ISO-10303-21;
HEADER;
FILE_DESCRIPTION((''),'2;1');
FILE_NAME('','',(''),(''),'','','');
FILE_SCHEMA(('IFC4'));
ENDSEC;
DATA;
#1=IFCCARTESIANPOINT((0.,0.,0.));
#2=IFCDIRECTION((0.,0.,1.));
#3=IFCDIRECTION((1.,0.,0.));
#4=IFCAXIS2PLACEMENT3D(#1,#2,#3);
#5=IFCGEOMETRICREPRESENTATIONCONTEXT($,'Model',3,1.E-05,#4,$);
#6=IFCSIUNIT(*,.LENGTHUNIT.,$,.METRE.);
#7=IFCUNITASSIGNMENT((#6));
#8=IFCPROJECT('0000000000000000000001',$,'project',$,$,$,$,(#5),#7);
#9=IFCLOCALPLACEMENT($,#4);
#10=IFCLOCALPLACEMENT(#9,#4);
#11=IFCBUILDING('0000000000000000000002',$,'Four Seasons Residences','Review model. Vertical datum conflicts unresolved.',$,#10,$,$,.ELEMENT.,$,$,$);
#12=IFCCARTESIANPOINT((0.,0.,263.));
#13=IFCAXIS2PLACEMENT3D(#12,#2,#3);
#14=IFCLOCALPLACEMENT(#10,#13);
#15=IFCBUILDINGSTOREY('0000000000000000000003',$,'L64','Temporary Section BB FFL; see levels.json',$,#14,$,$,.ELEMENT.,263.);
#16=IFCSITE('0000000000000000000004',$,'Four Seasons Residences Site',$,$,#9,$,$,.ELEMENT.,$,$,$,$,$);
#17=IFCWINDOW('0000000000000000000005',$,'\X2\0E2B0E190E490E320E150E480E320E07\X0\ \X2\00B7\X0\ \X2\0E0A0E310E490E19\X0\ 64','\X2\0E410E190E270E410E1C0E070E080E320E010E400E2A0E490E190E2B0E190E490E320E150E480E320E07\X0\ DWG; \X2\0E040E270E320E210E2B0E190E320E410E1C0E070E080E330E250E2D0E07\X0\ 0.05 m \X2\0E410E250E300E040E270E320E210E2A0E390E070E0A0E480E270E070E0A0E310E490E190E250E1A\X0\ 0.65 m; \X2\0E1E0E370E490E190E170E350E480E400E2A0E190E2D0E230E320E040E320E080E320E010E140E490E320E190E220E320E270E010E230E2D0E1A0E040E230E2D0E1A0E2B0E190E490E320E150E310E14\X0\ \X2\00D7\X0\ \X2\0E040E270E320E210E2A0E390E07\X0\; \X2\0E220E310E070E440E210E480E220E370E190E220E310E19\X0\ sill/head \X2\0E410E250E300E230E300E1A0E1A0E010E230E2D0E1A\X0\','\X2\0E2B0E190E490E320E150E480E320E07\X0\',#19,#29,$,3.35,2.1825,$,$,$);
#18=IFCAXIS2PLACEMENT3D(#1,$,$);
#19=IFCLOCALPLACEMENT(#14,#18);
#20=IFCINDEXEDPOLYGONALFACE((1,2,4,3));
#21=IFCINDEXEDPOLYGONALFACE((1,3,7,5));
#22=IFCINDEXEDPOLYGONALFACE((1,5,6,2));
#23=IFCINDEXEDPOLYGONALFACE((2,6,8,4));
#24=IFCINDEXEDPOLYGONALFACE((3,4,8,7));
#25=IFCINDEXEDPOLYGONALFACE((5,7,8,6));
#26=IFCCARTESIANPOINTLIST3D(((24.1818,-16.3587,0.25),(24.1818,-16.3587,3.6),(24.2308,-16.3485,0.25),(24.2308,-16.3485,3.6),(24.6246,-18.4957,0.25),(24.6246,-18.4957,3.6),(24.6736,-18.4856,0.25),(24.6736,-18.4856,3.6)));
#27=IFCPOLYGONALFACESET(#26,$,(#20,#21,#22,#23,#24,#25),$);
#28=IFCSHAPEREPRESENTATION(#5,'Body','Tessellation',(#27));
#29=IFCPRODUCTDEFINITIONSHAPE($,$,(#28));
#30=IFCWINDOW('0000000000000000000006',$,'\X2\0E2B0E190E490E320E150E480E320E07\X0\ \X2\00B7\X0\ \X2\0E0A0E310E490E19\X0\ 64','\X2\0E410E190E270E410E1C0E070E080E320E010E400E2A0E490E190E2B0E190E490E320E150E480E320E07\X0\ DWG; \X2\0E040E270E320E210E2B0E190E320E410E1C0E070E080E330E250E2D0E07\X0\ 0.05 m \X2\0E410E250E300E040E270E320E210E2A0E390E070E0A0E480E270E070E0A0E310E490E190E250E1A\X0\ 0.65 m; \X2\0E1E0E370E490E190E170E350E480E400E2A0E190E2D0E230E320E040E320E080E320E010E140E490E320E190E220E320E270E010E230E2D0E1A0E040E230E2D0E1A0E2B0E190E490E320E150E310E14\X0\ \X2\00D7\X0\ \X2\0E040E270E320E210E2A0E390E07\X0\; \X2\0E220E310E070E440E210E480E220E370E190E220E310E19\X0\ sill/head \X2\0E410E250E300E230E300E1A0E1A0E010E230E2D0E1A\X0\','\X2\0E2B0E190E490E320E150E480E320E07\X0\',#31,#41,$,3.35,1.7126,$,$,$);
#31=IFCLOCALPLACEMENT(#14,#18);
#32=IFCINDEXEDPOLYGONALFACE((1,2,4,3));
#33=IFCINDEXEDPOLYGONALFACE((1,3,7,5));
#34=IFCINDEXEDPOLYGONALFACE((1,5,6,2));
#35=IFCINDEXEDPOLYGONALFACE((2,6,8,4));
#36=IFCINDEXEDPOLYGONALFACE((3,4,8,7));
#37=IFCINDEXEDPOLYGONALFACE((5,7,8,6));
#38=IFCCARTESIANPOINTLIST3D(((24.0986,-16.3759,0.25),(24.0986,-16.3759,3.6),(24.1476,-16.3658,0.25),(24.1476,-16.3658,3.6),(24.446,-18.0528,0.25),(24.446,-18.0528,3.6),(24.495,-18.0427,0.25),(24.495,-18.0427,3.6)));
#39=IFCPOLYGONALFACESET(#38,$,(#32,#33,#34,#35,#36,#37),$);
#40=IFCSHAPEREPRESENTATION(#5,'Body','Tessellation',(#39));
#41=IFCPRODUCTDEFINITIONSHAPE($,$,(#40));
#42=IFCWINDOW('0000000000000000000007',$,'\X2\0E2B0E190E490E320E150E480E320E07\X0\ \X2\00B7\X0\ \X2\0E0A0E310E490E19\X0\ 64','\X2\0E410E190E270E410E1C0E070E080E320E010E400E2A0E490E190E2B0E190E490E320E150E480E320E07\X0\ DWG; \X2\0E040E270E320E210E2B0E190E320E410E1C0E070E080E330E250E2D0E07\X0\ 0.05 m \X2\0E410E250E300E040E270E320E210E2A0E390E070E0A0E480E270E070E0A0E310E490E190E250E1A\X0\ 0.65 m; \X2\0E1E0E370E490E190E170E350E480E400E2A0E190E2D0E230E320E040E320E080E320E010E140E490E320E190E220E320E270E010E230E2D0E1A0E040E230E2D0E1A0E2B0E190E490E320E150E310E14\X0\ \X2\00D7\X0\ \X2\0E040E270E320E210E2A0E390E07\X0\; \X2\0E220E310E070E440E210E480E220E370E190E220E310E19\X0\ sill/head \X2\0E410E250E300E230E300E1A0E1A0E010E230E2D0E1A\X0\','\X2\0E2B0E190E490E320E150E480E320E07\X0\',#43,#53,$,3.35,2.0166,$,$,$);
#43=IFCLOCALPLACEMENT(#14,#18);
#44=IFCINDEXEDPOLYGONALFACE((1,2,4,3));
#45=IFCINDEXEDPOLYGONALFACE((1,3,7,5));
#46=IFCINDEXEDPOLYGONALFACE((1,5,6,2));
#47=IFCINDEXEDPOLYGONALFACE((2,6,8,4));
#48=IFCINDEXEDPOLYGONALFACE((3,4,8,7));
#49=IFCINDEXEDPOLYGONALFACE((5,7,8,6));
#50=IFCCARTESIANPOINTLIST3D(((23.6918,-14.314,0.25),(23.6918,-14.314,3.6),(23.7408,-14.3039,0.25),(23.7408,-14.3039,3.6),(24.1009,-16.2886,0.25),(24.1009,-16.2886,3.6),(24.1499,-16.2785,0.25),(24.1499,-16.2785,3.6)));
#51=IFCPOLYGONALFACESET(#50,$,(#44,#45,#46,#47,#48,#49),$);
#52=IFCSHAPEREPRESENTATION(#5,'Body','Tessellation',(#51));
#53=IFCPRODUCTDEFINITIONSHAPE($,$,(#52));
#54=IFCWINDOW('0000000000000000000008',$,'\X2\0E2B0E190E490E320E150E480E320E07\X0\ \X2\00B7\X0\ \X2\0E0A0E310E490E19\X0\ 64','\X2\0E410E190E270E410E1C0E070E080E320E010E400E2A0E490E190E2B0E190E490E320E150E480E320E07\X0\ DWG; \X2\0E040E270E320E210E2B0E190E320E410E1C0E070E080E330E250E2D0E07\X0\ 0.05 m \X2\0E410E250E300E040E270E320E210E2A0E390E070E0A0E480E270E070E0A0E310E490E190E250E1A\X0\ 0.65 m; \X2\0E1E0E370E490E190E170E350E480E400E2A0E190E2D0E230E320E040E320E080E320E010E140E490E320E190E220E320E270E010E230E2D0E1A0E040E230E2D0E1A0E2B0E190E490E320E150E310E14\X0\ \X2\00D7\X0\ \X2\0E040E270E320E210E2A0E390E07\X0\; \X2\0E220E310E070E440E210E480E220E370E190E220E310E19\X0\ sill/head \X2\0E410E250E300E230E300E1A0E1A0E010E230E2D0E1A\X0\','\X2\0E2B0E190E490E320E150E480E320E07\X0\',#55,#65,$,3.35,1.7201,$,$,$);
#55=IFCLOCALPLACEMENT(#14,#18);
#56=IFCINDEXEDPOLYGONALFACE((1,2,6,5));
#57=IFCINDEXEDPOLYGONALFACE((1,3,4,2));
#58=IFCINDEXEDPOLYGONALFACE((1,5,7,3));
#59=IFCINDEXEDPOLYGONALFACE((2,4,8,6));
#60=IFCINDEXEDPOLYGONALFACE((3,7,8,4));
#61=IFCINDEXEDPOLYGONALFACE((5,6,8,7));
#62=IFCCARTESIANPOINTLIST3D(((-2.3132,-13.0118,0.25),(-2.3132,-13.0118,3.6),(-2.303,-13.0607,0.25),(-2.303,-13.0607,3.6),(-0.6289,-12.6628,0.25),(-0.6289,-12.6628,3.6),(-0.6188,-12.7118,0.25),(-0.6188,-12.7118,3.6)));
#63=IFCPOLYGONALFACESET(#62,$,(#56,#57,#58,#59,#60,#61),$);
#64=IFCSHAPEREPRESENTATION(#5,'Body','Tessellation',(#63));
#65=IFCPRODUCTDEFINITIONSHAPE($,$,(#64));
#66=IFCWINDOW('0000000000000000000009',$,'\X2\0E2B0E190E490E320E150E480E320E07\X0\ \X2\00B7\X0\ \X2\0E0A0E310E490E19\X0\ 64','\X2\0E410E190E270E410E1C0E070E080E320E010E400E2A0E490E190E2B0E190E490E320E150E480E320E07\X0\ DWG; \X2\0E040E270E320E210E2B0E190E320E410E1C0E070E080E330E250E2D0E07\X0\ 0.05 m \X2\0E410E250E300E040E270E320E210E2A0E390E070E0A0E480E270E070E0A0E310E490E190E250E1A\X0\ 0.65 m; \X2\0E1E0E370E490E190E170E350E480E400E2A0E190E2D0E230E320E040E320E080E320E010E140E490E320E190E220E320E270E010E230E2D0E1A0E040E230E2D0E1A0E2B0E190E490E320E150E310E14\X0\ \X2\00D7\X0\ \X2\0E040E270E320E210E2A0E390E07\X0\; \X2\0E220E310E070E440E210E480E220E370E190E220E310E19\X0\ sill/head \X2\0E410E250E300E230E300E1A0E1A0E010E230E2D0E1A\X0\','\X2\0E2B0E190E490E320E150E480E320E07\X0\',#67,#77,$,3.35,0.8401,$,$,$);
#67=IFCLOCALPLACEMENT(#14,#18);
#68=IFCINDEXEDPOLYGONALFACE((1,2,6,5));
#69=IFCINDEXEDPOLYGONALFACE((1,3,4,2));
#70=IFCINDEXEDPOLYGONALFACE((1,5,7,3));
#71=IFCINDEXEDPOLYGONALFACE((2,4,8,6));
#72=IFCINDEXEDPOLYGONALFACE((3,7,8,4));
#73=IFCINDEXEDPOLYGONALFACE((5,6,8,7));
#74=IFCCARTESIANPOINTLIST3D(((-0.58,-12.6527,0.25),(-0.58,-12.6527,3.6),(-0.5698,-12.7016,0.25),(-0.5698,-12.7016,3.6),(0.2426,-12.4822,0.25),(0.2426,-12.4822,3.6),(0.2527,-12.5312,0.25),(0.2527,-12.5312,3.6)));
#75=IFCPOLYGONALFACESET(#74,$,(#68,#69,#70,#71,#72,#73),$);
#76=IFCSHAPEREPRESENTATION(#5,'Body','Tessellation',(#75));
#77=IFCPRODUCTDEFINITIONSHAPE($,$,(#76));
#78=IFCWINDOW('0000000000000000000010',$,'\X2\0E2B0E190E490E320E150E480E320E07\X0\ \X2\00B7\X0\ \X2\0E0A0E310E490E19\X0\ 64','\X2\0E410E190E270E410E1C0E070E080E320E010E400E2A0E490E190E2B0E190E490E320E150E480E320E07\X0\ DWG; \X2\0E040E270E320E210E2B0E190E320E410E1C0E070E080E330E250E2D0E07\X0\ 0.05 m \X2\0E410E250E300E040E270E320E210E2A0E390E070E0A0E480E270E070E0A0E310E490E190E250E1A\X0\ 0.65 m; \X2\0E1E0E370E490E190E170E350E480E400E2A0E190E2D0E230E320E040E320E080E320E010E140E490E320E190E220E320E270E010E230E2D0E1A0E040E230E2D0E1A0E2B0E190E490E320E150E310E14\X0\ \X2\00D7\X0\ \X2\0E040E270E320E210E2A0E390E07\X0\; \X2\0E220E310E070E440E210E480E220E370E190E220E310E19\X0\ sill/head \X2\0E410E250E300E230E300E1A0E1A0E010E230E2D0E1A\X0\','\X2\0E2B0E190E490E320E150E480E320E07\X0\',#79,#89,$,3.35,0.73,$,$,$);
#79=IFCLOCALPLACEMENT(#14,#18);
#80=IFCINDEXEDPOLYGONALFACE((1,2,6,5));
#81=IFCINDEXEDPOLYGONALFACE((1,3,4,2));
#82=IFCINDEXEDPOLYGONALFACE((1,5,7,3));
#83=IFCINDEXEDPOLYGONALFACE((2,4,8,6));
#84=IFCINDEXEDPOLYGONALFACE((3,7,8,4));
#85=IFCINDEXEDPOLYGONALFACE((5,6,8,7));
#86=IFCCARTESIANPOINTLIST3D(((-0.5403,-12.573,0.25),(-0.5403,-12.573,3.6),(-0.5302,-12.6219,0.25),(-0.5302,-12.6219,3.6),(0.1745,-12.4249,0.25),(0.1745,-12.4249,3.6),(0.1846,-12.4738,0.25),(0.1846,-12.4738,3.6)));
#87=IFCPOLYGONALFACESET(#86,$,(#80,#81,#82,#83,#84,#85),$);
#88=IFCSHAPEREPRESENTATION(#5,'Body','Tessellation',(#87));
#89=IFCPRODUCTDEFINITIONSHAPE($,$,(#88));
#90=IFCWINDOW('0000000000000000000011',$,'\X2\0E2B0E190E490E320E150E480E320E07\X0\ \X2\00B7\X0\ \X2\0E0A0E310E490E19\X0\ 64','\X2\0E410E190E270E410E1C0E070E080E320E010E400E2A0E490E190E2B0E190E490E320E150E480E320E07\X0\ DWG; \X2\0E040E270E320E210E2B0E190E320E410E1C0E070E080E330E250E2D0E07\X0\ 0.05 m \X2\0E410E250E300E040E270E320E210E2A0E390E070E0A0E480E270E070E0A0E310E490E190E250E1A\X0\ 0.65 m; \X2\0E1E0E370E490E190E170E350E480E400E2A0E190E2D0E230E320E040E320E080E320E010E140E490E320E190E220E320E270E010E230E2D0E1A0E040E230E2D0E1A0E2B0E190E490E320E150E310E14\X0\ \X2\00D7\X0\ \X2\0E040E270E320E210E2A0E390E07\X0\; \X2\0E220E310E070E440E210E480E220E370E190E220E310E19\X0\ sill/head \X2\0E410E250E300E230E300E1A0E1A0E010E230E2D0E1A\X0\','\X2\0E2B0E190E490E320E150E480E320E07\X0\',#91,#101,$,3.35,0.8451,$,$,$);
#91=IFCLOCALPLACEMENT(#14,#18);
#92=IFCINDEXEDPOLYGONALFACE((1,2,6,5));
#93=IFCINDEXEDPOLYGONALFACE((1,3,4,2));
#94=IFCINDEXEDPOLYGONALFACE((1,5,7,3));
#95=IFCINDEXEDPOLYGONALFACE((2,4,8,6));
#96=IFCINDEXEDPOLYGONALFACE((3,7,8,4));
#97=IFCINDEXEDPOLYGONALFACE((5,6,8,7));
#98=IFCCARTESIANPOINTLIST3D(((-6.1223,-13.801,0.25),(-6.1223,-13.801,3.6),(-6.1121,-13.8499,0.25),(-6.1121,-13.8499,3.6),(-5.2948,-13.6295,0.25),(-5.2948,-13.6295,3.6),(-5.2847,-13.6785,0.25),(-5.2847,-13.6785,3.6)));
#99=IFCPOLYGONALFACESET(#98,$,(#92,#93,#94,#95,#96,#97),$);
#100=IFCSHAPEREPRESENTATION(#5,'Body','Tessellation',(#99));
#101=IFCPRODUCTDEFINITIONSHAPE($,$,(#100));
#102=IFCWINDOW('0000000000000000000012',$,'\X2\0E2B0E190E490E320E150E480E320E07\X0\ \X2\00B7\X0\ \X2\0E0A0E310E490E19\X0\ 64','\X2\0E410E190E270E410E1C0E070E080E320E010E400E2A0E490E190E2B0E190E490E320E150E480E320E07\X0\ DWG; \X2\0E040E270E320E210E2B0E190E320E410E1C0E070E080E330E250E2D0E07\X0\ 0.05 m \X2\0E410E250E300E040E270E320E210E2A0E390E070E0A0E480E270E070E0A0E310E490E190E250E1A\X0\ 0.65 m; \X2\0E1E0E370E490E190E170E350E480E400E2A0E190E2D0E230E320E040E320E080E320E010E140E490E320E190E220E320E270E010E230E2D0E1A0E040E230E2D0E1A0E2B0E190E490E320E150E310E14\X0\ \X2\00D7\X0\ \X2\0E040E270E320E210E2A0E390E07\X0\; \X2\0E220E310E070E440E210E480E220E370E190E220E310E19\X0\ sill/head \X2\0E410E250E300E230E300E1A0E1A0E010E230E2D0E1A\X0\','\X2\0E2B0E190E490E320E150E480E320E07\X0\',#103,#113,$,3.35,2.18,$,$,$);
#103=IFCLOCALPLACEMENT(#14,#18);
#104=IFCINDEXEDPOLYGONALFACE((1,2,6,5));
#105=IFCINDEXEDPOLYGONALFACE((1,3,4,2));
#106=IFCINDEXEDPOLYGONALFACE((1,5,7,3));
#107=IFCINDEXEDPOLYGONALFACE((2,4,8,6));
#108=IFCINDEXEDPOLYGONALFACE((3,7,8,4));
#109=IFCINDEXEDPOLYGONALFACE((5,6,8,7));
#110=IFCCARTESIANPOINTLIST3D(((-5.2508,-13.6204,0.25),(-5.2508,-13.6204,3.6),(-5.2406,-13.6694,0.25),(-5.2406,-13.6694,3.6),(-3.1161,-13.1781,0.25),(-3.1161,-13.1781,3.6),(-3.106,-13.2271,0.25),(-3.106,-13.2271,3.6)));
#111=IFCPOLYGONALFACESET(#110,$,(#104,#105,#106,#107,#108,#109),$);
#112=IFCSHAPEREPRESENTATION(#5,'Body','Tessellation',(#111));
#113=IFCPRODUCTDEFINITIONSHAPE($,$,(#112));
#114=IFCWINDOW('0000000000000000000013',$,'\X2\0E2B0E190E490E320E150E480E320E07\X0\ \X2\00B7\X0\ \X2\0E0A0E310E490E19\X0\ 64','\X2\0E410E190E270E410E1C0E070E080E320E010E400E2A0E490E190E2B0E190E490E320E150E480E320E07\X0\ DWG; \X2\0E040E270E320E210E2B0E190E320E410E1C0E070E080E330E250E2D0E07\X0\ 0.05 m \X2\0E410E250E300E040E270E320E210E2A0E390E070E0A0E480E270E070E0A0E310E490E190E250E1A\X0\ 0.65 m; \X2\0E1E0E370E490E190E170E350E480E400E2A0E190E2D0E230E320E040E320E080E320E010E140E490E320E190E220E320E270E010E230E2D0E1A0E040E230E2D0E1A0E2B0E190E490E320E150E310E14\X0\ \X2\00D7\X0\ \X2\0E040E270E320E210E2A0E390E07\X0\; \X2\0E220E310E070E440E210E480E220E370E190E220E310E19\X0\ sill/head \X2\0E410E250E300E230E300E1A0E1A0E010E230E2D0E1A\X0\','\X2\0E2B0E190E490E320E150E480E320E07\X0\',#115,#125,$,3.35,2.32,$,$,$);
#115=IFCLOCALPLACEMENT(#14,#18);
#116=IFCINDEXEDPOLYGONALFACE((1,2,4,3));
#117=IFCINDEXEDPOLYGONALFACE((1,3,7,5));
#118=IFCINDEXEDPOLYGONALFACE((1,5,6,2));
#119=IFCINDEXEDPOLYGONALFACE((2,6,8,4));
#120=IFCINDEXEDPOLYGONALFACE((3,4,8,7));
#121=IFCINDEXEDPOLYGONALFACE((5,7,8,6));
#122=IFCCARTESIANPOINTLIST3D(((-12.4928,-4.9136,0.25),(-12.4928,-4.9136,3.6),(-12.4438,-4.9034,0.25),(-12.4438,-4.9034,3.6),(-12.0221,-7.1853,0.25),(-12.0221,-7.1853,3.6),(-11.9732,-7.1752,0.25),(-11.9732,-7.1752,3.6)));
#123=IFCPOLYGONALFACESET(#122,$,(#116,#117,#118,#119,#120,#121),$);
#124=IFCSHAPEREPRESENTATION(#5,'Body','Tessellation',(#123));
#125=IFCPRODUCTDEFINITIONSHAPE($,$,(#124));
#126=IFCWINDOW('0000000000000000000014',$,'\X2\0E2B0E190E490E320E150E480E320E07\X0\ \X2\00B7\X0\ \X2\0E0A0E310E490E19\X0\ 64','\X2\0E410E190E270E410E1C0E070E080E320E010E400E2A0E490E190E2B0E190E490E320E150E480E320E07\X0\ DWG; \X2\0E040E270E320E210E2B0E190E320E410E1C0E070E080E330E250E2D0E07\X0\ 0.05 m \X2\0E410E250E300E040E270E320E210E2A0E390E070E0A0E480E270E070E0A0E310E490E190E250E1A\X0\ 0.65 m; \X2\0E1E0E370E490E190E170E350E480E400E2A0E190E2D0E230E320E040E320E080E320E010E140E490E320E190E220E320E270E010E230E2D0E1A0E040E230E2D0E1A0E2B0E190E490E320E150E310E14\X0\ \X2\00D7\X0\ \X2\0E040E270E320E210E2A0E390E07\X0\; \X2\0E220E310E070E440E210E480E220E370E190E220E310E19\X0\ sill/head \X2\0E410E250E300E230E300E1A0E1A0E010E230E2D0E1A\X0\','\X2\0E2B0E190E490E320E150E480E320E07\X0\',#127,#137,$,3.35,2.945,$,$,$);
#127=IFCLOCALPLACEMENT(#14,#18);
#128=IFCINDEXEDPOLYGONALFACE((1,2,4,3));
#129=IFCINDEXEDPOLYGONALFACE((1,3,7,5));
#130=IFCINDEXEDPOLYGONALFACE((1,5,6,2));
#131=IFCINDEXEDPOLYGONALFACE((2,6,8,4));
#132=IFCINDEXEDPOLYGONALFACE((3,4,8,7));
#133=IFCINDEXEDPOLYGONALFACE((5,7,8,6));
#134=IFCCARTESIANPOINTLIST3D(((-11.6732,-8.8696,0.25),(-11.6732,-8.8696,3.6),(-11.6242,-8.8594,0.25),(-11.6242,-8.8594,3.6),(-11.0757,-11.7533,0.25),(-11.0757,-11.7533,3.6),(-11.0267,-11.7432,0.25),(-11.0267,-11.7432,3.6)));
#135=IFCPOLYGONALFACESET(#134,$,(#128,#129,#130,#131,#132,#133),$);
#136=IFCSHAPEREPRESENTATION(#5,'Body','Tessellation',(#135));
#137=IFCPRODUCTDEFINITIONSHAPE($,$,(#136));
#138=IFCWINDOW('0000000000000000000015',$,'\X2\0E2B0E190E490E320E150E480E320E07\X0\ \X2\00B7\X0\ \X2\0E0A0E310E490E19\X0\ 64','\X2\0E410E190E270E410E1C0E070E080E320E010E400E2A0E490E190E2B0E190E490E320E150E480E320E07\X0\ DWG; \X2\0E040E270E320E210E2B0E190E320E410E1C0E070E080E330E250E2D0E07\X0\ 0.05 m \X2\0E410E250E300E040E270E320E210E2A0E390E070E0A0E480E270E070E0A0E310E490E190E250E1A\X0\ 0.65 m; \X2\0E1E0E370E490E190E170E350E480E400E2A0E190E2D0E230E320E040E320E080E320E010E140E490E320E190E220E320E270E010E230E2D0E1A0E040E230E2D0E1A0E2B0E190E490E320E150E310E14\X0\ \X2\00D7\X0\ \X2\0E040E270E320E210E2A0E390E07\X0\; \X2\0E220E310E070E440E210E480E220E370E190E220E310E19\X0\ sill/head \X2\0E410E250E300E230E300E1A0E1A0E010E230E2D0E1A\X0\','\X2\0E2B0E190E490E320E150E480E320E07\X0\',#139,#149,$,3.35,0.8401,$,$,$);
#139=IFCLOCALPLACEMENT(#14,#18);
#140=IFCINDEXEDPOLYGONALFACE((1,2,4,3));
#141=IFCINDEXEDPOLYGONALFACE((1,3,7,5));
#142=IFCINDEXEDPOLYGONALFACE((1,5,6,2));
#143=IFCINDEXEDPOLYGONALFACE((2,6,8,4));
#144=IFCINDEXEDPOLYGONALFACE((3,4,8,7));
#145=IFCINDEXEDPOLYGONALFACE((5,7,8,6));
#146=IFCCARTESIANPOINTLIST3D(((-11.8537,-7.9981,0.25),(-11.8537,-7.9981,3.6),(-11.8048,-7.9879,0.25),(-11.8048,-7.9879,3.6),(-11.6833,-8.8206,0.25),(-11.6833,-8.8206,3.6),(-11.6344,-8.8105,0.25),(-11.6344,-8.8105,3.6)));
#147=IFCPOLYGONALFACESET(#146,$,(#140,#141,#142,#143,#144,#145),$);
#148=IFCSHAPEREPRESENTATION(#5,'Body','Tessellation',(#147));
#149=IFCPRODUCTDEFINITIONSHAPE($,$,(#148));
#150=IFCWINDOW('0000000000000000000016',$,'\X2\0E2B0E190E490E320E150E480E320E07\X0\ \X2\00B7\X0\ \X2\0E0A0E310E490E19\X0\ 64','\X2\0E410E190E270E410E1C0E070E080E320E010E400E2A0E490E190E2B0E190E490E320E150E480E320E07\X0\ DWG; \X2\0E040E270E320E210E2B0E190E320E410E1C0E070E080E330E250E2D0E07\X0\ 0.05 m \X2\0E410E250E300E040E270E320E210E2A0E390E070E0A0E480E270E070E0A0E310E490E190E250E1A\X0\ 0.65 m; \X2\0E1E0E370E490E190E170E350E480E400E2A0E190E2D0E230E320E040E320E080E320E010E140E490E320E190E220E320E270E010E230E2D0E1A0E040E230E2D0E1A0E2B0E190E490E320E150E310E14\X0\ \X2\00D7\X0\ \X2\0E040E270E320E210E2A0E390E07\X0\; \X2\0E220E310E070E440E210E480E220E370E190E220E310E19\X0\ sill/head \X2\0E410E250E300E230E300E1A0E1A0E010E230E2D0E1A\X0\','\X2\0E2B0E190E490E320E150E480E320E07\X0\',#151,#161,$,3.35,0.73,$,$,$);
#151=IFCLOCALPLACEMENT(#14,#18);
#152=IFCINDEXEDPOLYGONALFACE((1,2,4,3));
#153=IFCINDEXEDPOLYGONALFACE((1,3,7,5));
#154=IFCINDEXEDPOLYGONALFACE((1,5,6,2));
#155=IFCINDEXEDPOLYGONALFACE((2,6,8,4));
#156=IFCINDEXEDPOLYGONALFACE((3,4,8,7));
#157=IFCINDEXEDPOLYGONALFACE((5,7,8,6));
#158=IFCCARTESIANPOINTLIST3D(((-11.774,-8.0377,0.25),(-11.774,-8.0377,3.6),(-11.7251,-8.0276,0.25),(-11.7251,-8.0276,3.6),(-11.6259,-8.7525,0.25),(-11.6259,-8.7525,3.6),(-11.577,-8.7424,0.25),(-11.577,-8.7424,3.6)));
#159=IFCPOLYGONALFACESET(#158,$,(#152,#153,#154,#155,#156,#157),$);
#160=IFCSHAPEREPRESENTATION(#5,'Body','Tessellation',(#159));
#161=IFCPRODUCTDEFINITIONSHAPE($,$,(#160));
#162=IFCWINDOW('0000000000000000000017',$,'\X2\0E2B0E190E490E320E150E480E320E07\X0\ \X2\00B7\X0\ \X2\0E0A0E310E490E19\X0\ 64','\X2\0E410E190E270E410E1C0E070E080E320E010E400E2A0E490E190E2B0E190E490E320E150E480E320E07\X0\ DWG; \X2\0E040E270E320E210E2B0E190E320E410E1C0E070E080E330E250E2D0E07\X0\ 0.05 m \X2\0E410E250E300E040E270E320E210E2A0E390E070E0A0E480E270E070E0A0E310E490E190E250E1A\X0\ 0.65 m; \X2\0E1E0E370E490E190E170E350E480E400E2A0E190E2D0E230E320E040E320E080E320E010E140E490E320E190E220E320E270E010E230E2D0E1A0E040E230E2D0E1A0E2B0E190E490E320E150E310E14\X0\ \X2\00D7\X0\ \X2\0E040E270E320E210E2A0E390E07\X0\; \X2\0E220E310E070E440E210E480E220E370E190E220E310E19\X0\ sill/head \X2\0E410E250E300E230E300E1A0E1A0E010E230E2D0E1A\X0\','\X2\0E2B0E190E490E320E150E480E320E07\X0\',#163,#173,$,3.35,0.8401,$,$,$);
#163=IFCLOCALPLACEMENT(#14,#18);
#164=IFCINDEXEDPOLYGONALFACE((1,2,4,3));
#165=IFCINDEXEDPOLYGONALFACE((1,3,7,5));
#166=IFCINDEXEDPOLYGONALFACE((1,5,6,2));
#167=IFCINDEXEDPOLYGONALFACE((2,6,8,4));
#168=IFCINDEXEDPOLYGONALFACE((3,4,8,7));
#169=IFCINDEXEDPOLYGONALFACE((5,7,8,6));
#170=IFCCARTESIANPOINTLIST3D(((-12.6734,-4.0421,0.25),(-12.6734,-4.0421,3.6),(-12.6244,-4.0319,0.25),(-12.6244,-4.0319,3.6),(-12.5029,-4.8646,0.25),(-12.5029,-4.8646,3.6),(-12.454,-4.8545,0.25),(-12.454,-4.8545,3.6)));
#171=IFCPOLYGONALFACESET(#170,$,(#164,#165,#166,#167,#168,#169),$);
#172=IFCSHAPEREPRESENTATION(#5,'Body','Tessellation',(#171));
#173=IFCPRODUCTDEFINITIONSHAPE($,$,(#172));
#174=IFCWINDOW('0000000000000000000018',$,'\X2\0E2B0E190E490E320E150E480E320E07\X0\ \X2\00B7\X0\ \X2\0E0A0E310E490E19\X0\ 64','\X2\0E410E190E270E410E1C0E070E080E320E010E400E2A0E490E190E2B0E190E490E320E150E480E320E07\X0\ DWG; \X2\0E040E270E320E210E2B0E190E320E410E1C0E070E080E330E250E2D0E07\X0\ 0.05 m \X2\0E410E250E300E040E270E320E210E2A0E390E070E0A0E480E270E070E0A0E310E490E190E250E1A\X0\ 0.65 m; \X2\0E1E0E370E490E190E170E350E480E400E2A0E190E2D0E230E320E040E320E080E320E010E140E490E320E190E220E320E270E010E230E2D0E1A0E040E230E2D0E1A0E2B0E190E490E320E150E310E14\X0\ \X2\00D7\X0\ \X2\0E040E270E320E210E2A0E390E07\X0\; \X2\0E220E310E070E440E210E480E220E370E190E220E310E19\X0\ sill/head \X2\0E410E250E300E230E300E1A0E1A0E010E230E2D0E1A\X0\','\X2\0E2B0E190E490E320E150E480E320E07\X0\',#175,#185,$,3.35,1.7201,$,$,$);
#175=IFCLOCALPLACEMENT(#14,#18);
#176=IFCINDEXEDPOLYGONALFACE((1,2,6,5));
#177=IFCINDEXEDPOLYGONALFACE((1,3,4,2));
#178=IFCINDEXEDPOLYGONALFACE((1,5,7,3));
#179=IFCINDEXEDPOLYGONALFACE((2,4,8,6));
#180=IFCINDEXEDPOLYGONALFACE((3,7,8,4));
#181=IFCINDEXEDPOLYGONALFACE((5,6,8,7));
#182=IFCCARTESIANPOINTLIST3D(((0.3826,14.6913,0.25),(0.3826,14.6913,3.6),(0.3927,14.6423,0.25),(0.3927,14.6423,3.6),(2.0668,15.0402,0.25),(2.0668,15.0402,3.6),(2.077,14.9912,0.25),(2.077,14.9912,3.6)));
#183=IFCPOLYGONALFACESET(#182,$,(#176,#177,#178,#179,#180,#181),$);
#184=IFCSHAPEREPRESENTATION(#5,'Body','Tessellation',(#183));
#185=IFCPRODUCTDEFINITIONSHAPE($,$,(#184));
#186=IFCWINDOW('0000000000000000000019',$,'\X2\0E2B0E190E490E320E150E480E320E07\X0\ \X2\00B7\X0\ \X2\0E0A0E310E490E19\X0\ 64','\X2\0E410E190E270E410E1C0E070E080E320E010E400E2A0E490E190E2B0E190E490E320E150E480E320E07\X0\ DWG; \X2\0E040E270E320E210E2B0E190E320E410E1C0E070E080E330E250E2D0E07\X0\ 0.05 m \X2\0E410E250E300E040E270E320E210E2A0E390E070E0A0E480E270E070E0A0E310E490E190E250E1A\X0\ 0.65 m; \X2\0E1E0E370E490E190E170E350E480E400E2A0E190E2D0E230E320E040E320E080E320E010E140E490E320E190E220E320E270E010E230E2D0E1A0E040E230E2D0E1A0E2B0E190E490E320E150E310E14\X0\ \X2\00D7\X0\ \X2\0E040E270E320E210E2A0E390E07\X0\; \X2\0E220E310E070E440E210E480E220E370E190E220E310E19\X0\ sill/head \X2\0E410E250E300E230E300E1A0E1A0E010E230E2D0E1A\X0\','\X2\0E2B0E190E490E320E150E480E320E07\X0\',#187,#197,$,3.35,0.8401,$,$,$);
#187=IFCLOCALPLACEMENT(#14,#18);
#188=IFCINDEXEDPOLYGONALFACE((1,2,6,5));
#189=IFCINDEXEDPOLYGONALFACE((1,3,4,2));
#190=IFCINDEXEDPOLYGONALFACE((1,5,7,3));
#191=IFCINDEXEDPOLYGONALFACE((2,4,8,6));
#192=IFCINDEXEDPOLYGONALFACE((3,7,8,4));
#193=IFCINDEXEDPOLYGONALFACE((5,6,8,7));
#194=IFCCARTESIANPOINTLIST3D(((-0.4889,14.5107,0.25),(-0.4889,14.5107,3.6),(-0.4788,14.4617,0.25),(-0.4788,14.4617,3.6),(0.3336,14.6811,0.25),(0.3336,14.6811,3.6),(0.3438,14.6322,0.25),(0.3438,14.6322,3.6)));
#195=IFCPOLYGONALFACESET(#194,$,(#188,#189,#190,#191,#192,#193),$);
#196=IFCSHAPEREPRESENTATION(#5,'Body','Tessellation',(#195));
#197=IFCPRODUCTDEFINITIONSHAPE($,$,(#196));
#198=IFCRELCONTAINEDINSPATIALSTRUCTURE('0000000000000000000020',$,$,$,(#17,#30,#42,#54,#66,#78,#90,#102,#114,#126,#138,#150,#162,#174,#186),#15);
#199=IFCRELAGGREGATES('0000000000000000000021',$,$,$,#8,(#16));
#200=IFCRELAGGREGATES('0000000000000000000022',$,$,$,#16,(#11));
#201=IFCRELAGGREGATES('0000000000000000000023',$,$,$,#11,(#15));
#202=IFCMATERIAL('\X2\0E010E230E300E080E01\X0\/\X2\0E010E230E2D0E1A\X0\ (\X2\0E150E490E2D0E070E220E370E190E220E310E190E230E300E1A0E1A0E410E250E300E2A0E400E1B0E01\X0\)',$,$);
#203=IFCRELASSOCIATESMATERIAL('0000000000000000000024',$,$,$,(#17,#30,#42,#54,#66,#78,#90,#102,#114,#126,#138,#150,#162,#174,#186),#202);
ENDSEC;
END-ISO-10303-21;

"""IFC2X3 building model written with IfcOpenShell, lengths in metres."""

from ifc_helpers import new_model, si_unit, frame, origin_with_axes, place, context, project, spatial, polyline, outline, extrude, material, element, save


model = new_model("IFC2X3")

# Units and contexts
model_context = context("Model", 3, precision=1e-05, world=origin_with_axes())
ifc_project = project(units=[si_unit("LENGTHUNIT", "METRE")], contexts=[model_context])

# Site, building, storey
site_placement = place(None, origin_with_axes())
site = spatial("IfcSite", under=ifc_project, at=site_placement, Name="Four Seasons Residences Site", CompositionType="ELEMENT")
building_placement = place(site_placement, origin_with_axes())
building = spatial("IfcBuilding", under=site, at=building_placement, Name="Four Seasons Residences", Description="Review model. Vertical datum conflicts unresolved.", CompositionType="ELEMENT")
storey_placement = place(building_placement, frame((0.0, 0.0, 263.0), z_axis=(0.0, 0.0, 1.0), x_axis=(1.0, 0.0, 0.0)))
storey = spatial("IfcBuildingStorey", under=building, at=storey_placement, Name="L64", Description="Temporary Section BB FFL; see levels.json", CompositionType="ELEMENT", Elevation=263.0)

# Windows
ifc_material = material(Name="กระจก/กรอบ (ต้องยืนยันระบบและสเปก)")
window_1_placement = place(storey_placement, origin_with_axes())
element("IfcWindow", 1, at=window_1_placement, inside=storey, material=ifc_material, Name="หน้าต่าง · ชั้น 64", Description="แนวแผงจากเส้นหน้าต่าง DWG; ความหนาแผงจำลอง 0.05 m และความสูงช่วงชั้นลบ 0.65 m; พื้นที่เสนอราคาจากด้านยาวกรอบครอบหน้าตัด × ความสูง; ยังไม่ยืนยัน sill/head และระบบกรอบ", ObjectType="หน้าต่าง", OverallHeight=3.35, OverallWidth=2.1825, context=model_context, shape_type="SweptSolid", body=[
    extrude(outline(polyline([(24.6736, -18.4856), (24.6246, -18.4957), (24.1818, -16.3587), (24.2308, -16.3485), (24.6736, -18.4856)])), frame((0.0, 0.0, 0.25), z_axis=(0.0, 0.0, 1.0), x_axis=(1.0, 0.0, 0.0)), (0.0, 0.0, 1.0), 3.35),
])
window_2_placement = place(storey_placement, origin_with_axes())
element("IfcWindow", 2, at=window_2_placement, inside=storey, material=ifc_material, Name="หน้าต่าง · ชั้น 64", Description="แนวแผงจากเส้นหน้าต่าง DWG; ความหนาแผงจำลอง 0.05 m และความสูงช่วงชั้นลบ 0.65 m; พื้นที่เสนอราคาจากด้านยาวกรอบครอบหน้าตัด × ความสูง; ยังไม่ยืนยัน sill/head และระบบกรอบ", ObjectType="หน้าต่าง", OverallHeight=3.35, OverallWidth=1.7126, context=model_context, shape_type="SweptSolid", body=[
    extrude(outline(polyline([(24.0986, -16.3759), (24.1476, -16.3658), (24.495, -18.0427), (24.446, -18.0528), (24.0986, -16.3759)])), frame((0.0, 0.0, 0.25), z_axis=(0.0, 0.0, 1.0), x_axis=(1.0, 0.0, 0.0)), (0.0, 0.0, 1.0), 3.35),
])
window_3_placement = place(storey_placement, origin_with_axes())
element("IfcWindow", 3, at=window_3_placement, inside=storey, material=ifc_material, Name="หน้าต่าง · ชั้น 64", Description="แนวแผงจากเส้นหน้าต่าง DWG; ความหนาแผงจำลอง 0.05 m และความสูงช่วงชั้นลบ 0.65 m; พื้นที่เสนอราคาจากด้านยาวกรอบครอบหน้าตัด × ความสูง; ยังไม่ยืนยัน sill/head และระบบกรอบ", ObjectType="หน้าต่าง", OverallHeight=3.35, OverallWidth=2.0166, context=model_context, shape_type="SweptSolid", body=[
    extrude(outline(polyline([(23.6918, -14.314), (23.7408, -14.3039), (24.1499, -16.2785), (24.1009, -16.2886), (23.6918, -14.314)])), frame((0.0, 0.0, 0.25), z_axis=(0.0, 0.0, 1.0), x_axis=(1.0, 0.0, 0.0)), (0.0, 0.0, 1.0), 3.35),
])
window_4_placement = place(storey_placement, origin_with_axes())
element("IfcWindow", 4, at=window_4_placement, inside=storey, material=ifc_material, Name="หน้าต่าง · ชั้น 64", Description="แนวแผงจากเส้นหน้าต่าง DWG; ความหนาแผงจำลอง 0.05 m และความสูงช่วงชั้นลบ 0.65 m; พื้นที่เสนอราคาจากด้านยาวกรอบครอบหน้าตัด × ความสูง; ยังไม่ยืนยัน sill/head และระบบกรอบ", ObjectType="หน้าต่าง", OverallHeight=3.35, OverallWidth=1.7201, context=model_context, shape_type="SweptSolid", body=[
    extrude(outline(polyline([(-0.6289, -12.6628), (-0.6188, -12.7118), (-2.303, -13.0607), (-2.3132, -13.0118), (-0.6289, -12.6628)])), frame((0.0, 0.0, 0.25), z_axis=(0.0, 0.0, 1.0), x_axis=(1.0, 0.0, 0.0)), (0.0, 0.0, 1.0), 3.35),
])
window_5_placement = place(storey_placement, origin_with_axes())
element("IfcWindow", 5, at=window_5_placement, inside=storey, material=ifc_material, Name="หน้าต่าง · ชั้น 64", Description="แนวแผงจากเส้นหน้าต่าง DWG; ความหนาแผงจำลอง 0.05 m และความสูงช่วงชั้นลบ 0.65 m; พื้นที่เสนอราคาจากด้านยาวกรอบครอบหน้าตัด × ความสูง; ยังไม่ยืนยัน sill/head และระบบกรอบ", ObjectType="หน้าต่าง", OverallHeight=3.35, OverallWidth=0.8401, context=model_context, shape_type="SweptSolid", body=[
    extrude(outline(polyline([(0.2426, -12.4822), (0.2527, -12.5312), (-0.5698, -12.7016), (-0.58, -12.6527), (0.2426, -12.4822)])), frame((0.0, 0.0, 0.25), z_axis=(0.0, 0.0, 1.0), x_axis=(1.0, 0.0, 0.0)), (0.0, 0.0, 1.0), 3.35),
])
window_6_placement = place(storey_placement, origin_with_axes())
element("IfcWindow", 6, at=window_6_placement, inside=storey, material=ifc_material, Name="หน้าต่าง · ชั้น 64", Description="แนวแผงจากเส้นหน้าต่าง DWG; ความหนาแผงจำลอง 0.05 m และความสูงช่วงชั้นลบ 0.65 m; พื้นที่เสนอราคาจากด้านยาวกรอบครอบหน้าตัด × ความสูง; ยังไม่ยืนยัน sill/head และระบบกรอบ", ObjectType="หน้าต่าง", OverallHeight=3.35, OverallWidth=0.73, context=model_context, shape_type="SweptSolid", body=[
    extrude(outline(polyline([(0.1745, -12.4249), (0.1846, -12.4738), (-0.5302, -12.6219), (-0.5403, -12.573), (0.1745, -12.4249)])), frame((0.0, 0.0, 0.25), z_axis=(0.0, 0.0, 1.0), x_axis=(1.0, 0.0, 0.0)), (0.0, 0.0, 1.0), 3.35),
])
window_7_placement = place(storey_placement, origin_with_axes())
element("IfcWindow", 7, at=window_7_placement, inside=storey, material=ifc_material, Name="หน้าต่าง · ชั้น 64", Description="แนวแผงจากเส้นหน้าต่าง DWG; ความหนาแผงจำลอง 0.05 m และความสูงช่วงชั้นลบ 0.65 m; พื้นที่เสนอราคาจากด้านยาวกรอบครอบหน้าตัด × ความสูง; ยังไม่ยืนยัน sill/head และระบบกรอบ", ObjectType="หน้าต่าง", OverallHeight=3.35, OverallWidth=0.8451, context=model_context, shape_type="SweptSolid", body=[
    extrude(outline(polyline([(-5.2948, -13.6295), (-5.2847, -13.6785), (-6.1121, -13.8499), (-6.1223, -13.801), (-5.2948, -13.6295)])), frame((0.0, 0.0, 0.25), z_axis=(0.0, 0.0, 1.0), x_axis=(1.0, 0.0, 0.0)), (0.0, 0.0, 1.0), 3.35),
])
window_8_placement = place(storey_placement, origin_with_axes())
element("IfcWindow", 8, at=window_8_placement, inside=storey, material=ifc_material, Name="หน้าต่าง · ชั้น 64", Description="แนวแผงจากเส้นหน้าต่าง DWG; ความหนาแผงจำลอง 0.05 m และความสูงช่วงชั้นลบ 0.65 m; พื้นที่เสนอราคาจากด้านยาวกรอบครอบหน้าตัด × ความสูง; ยังไม่ยืนยัน sill/head และระบบกรอบ", ObjectType="หน้าต่าง", OverallHeight=3.35, OverallWidth=2.18, context=model_context, shape_type="SweptSolid", body=[
    extrude(outline(polyline([(-3.1161, -13.1781), (-3.106, -13.2271), (-5.2406, -13.6694), (-5.2508, -13.6204), (-3.1161, -13.1781)])), frame((0.0, 0.0, 0.25), z_axis=(0.0, 0.0, 1.0), x_axis=(1.0, 0.0, 0.0)), (0.0, 0.0, 1.0), 3.35),
])
window_9_placement = place(storey_placement, origin_with_axes())
element("IfcWindow", 9, at=window_9_placement, inside=storey, material=ifc_material, Name="หน้าต่าง · ชั้น 64", Description="แนวแผงจากเส้นหน้าต่าง DWG; ความหนาแผงจำลอง 0.05 m และความสูงช่วงชั้นลบ 0.65 m; พื้นที่เสนอราคาจากด้านยาวกรอบครอบหน้าตัด × ความสูง; ยังไม่ยืนยัน sill/head และระบบกรอบ", ObjectType="หน้าต่าง", OverallHeight=3.35, OverallWidth=2.32, context=model_context, shape_type="SweptSolid", body=[
    extrude(outline(polyline([(-11.9732, -7.1752), (-12.0221, -7.1853), (-12.4928, -4.9136), (-12.4438, -4.9034), (-11.9732, -7.1752)])), frame((0.0, 0.0, 0.25), z_axis=(0.0, 0.0, 1.0), x_axis=(1.0, 0.0, 0.0)), (0.0, 0.0, 1.0), 3.35),
])
window_10_placement = place(storey_placement, origin_with_axes())
element("IfcWindow", 10, at=window_10_placement, inside=storey, material=ifc_material, Name="หน้าต่าง · ชั้น 64", Description="แนวแผงจากเส้นหน้าต่าง DWG; ความหนาแผงจำลอง 0.05 m และความสูงช่วงชั้นลบ 0.65 m; พื้นที่เสนอราคาจากด้านยาวกรอบครอบหน้าตัด × ความสูง; ยังไม่ยืนยัน sill/head และระบบกรอบ", ObjectType="หน้าต่าง", OverallHeight=3.35, OverallWidth=2.945, context=model_context, shape_type="SweptSolid", body=[
    extrude(outline(polyline([(-11.6732, -8.8696), (-11.6242, -8.8594), (-11.0267, -11.7432), (-11.0757, -11.7533), (-11.6732, -8.8696)])), frame((0.0, 0.0, 0.25), z_axis=(0.0, 0.0, 1.0), x_axis=(1.0, 0.0, 0.0)), (0.0, 0.0, 1.0), 3.35),
])
window_11_placement = place(storey_placement, origin_with_axes())
element("IfcWindow", 11, at=window_11_placement, inside=storey, material=ifc_material, Name="หน้าต่าง · ชั้น 64", Description="แนวแผงจากเส้นหน้าต่าง DWG; ความหนาแผงจำลอง 0.05 m และความสูงช่วงชั้นลบ 0.65 m; พื้นที่เสนอราคาจากด้านยาวกรอบครอบหน้าตัด × ความสูง; ยังไม่ยืนยัน sill/head และระบบกรอบ", ObjectType="หน้าต่าง", OverallHeight=3.35, OverallWidth=0.8401, context=model_context, shape_type="SweptSolid", body=[
    extrude(outline(polyline([(-11.8537, -7.9981), (-11.8048, -7.9879), (-11.6344, -8.8105), (-11.6833, -8.8206), (-11.8537, -7.9981)])), frame((0.0, 0.0, 0.25), z_axis=(0.0, 0.0, 1.0), x_axis=(1.0, 0.0, 0.0)), (0.0, 0.0, 1.0), 3.35),
])
window_12_placement = place(storey_placement, origin_with_axes())
element("IfcWindow", 12, at=window_12_placement, inside=storey, material=ifc_material, Name="หน้าต่าง · ชั้น 64", Description="แนวแผงจากเส้นหน้าต่าง DWG; ความหนาแผงจำลอง 0.05 m และความสูงช่วงชั้นลบ 0.65 m; พื้นที่เสนอราคาจากด้านยาวกรอบครอบหน้าตัด × ความสูง; ยังไม่ยืนยัน sill/head และระบบกรอบ", ObjectType="หน้าต่าง", OverallHeight=3.35, OverallWidth=0.73, context=model_context, shape_type="SweptSolid", body=[
    extrude(outline(polyline([(-11.774, -8.0377), (-11.7251, -8.0276), (-11.577, -8.7424), (-11.6259, -8.7525), (-11.774, -8.0377)])), frame((0.0, 0.0, 0.25), z_axis=(0.0, 0.0, 1.0), x_axis=(1.0, 0.0, 0.0)), (0.0, 0.0, 1.0), 3.35),
])
window_13_placement = place(storey_placement, origin_with_axes())
element("IfcWindow", 13, at=window_13_placement, inside=storey, material=ifc_material, Name="หน้าต่าง · ชั้น 64", Description="แนวแผงจากเส้นหน้าต่าง DWG; ความหนาแผงจำลอง 0.05 m และความสูงช่วงชั้นลบ 0.65 m; พื้นที่เสนอราคาจากด้านยาวกรอบครอบหน้าตัด × ความสูง; ยังไม่ยืนยัน sill/head และระบบกรอบ", ObjectType="หน้าต่าง", OverallHeight=3.35, OverallWidth=0.8401, context=model_context, shape_type="SweptSolid", body=[
    extrude(outline(polyline([(-12.454, -4.8545), (-12.5029, -4.8646), (-12.6734, -4.0421), (-12.6244, -4.0319), (-12.454, -4.8545)])), frame((0.0, 0.0, 0.25), z_axis=(0.0, 0.0, 1.0), x_axis=(1.0, 0.0, 0.0)), (0.0, 0.0, 1.0), 3.35),
])
window_14_placement = place(storey_placement, origin_with_axes())
element("IfcWindow", 14, at=window_14_placement, inside=storey, material=ifc_material, Name="หน้าต่าง · ชั้น 64", Description="แนวแผงจากเส้นหน้าต่าง DWG; ความหนาแผงจำลอง 0.05 m และความสูงช่วงชั้นลบ 0.65 m; พื้นที่เสนอราคาจากด้านยาวกรอบครอบหน้าตัด × ความสูง; ยังไม่ยืนยัน sill/head และระบบกรอบ", ObjectType="หน้าต่าง", OverallHeight=3.35, OverallWidth=1.7201, context=model_context, shape_type="SweptSolid", body=[
    extrude(outline(polyline([(0.3927, 14.6423), (0.3826, 14.6913), (2.0668, 15.0402), (2.077, 14.9912), (0.3927, 14.6423)])), frame((0.0, 0.0, 0.25), z_axis=(0.0, 0.0, 1.0), x_axis=(1.0, 0.0, 0.0)), (0.0, 0.0, 1.0), 3.35),
])
window_15_placement = place(storey_placement, origin_with_axes())
element("IfcWindow", 15, at=window_15_placement, inside=storey, material=ifc_material, Name="หน้าต่าง · ชั้น 64", Description="แนวแผงจากเส้นหน้าต่าง DWG; ความหนาแผงจำลอง 0.05 m และความสูงช่วงชั้นลบ 0.65 m; พื้นที่เสนอราคาจากด้านยาวกรอบครอบหน้าตัด × ความสูง; ยังไม่ยืนยัน sill/head และระบบกรอบ", ObjectType="หน้าต่าง", OverallHeight=3.35, OverallWidth=0.8401, context=model_context, shape_type="SweptSolid", body=[
    extrude(outline(polyline([(-0.4788, 14.4617), (-0.4889, 14.5107), (0.3336, 14.6811), (0.3438, 14.6322), (-0.4788, 14.4617)])), frame((0.0, 0.0, 0.25), z_axis=(0.0, 0.0, 1.0), x_axis=(1.0, 0.0, 0.0)), (0.0, 0.0, 1.0), 3.35),
])

save(model, "model.ifc")
